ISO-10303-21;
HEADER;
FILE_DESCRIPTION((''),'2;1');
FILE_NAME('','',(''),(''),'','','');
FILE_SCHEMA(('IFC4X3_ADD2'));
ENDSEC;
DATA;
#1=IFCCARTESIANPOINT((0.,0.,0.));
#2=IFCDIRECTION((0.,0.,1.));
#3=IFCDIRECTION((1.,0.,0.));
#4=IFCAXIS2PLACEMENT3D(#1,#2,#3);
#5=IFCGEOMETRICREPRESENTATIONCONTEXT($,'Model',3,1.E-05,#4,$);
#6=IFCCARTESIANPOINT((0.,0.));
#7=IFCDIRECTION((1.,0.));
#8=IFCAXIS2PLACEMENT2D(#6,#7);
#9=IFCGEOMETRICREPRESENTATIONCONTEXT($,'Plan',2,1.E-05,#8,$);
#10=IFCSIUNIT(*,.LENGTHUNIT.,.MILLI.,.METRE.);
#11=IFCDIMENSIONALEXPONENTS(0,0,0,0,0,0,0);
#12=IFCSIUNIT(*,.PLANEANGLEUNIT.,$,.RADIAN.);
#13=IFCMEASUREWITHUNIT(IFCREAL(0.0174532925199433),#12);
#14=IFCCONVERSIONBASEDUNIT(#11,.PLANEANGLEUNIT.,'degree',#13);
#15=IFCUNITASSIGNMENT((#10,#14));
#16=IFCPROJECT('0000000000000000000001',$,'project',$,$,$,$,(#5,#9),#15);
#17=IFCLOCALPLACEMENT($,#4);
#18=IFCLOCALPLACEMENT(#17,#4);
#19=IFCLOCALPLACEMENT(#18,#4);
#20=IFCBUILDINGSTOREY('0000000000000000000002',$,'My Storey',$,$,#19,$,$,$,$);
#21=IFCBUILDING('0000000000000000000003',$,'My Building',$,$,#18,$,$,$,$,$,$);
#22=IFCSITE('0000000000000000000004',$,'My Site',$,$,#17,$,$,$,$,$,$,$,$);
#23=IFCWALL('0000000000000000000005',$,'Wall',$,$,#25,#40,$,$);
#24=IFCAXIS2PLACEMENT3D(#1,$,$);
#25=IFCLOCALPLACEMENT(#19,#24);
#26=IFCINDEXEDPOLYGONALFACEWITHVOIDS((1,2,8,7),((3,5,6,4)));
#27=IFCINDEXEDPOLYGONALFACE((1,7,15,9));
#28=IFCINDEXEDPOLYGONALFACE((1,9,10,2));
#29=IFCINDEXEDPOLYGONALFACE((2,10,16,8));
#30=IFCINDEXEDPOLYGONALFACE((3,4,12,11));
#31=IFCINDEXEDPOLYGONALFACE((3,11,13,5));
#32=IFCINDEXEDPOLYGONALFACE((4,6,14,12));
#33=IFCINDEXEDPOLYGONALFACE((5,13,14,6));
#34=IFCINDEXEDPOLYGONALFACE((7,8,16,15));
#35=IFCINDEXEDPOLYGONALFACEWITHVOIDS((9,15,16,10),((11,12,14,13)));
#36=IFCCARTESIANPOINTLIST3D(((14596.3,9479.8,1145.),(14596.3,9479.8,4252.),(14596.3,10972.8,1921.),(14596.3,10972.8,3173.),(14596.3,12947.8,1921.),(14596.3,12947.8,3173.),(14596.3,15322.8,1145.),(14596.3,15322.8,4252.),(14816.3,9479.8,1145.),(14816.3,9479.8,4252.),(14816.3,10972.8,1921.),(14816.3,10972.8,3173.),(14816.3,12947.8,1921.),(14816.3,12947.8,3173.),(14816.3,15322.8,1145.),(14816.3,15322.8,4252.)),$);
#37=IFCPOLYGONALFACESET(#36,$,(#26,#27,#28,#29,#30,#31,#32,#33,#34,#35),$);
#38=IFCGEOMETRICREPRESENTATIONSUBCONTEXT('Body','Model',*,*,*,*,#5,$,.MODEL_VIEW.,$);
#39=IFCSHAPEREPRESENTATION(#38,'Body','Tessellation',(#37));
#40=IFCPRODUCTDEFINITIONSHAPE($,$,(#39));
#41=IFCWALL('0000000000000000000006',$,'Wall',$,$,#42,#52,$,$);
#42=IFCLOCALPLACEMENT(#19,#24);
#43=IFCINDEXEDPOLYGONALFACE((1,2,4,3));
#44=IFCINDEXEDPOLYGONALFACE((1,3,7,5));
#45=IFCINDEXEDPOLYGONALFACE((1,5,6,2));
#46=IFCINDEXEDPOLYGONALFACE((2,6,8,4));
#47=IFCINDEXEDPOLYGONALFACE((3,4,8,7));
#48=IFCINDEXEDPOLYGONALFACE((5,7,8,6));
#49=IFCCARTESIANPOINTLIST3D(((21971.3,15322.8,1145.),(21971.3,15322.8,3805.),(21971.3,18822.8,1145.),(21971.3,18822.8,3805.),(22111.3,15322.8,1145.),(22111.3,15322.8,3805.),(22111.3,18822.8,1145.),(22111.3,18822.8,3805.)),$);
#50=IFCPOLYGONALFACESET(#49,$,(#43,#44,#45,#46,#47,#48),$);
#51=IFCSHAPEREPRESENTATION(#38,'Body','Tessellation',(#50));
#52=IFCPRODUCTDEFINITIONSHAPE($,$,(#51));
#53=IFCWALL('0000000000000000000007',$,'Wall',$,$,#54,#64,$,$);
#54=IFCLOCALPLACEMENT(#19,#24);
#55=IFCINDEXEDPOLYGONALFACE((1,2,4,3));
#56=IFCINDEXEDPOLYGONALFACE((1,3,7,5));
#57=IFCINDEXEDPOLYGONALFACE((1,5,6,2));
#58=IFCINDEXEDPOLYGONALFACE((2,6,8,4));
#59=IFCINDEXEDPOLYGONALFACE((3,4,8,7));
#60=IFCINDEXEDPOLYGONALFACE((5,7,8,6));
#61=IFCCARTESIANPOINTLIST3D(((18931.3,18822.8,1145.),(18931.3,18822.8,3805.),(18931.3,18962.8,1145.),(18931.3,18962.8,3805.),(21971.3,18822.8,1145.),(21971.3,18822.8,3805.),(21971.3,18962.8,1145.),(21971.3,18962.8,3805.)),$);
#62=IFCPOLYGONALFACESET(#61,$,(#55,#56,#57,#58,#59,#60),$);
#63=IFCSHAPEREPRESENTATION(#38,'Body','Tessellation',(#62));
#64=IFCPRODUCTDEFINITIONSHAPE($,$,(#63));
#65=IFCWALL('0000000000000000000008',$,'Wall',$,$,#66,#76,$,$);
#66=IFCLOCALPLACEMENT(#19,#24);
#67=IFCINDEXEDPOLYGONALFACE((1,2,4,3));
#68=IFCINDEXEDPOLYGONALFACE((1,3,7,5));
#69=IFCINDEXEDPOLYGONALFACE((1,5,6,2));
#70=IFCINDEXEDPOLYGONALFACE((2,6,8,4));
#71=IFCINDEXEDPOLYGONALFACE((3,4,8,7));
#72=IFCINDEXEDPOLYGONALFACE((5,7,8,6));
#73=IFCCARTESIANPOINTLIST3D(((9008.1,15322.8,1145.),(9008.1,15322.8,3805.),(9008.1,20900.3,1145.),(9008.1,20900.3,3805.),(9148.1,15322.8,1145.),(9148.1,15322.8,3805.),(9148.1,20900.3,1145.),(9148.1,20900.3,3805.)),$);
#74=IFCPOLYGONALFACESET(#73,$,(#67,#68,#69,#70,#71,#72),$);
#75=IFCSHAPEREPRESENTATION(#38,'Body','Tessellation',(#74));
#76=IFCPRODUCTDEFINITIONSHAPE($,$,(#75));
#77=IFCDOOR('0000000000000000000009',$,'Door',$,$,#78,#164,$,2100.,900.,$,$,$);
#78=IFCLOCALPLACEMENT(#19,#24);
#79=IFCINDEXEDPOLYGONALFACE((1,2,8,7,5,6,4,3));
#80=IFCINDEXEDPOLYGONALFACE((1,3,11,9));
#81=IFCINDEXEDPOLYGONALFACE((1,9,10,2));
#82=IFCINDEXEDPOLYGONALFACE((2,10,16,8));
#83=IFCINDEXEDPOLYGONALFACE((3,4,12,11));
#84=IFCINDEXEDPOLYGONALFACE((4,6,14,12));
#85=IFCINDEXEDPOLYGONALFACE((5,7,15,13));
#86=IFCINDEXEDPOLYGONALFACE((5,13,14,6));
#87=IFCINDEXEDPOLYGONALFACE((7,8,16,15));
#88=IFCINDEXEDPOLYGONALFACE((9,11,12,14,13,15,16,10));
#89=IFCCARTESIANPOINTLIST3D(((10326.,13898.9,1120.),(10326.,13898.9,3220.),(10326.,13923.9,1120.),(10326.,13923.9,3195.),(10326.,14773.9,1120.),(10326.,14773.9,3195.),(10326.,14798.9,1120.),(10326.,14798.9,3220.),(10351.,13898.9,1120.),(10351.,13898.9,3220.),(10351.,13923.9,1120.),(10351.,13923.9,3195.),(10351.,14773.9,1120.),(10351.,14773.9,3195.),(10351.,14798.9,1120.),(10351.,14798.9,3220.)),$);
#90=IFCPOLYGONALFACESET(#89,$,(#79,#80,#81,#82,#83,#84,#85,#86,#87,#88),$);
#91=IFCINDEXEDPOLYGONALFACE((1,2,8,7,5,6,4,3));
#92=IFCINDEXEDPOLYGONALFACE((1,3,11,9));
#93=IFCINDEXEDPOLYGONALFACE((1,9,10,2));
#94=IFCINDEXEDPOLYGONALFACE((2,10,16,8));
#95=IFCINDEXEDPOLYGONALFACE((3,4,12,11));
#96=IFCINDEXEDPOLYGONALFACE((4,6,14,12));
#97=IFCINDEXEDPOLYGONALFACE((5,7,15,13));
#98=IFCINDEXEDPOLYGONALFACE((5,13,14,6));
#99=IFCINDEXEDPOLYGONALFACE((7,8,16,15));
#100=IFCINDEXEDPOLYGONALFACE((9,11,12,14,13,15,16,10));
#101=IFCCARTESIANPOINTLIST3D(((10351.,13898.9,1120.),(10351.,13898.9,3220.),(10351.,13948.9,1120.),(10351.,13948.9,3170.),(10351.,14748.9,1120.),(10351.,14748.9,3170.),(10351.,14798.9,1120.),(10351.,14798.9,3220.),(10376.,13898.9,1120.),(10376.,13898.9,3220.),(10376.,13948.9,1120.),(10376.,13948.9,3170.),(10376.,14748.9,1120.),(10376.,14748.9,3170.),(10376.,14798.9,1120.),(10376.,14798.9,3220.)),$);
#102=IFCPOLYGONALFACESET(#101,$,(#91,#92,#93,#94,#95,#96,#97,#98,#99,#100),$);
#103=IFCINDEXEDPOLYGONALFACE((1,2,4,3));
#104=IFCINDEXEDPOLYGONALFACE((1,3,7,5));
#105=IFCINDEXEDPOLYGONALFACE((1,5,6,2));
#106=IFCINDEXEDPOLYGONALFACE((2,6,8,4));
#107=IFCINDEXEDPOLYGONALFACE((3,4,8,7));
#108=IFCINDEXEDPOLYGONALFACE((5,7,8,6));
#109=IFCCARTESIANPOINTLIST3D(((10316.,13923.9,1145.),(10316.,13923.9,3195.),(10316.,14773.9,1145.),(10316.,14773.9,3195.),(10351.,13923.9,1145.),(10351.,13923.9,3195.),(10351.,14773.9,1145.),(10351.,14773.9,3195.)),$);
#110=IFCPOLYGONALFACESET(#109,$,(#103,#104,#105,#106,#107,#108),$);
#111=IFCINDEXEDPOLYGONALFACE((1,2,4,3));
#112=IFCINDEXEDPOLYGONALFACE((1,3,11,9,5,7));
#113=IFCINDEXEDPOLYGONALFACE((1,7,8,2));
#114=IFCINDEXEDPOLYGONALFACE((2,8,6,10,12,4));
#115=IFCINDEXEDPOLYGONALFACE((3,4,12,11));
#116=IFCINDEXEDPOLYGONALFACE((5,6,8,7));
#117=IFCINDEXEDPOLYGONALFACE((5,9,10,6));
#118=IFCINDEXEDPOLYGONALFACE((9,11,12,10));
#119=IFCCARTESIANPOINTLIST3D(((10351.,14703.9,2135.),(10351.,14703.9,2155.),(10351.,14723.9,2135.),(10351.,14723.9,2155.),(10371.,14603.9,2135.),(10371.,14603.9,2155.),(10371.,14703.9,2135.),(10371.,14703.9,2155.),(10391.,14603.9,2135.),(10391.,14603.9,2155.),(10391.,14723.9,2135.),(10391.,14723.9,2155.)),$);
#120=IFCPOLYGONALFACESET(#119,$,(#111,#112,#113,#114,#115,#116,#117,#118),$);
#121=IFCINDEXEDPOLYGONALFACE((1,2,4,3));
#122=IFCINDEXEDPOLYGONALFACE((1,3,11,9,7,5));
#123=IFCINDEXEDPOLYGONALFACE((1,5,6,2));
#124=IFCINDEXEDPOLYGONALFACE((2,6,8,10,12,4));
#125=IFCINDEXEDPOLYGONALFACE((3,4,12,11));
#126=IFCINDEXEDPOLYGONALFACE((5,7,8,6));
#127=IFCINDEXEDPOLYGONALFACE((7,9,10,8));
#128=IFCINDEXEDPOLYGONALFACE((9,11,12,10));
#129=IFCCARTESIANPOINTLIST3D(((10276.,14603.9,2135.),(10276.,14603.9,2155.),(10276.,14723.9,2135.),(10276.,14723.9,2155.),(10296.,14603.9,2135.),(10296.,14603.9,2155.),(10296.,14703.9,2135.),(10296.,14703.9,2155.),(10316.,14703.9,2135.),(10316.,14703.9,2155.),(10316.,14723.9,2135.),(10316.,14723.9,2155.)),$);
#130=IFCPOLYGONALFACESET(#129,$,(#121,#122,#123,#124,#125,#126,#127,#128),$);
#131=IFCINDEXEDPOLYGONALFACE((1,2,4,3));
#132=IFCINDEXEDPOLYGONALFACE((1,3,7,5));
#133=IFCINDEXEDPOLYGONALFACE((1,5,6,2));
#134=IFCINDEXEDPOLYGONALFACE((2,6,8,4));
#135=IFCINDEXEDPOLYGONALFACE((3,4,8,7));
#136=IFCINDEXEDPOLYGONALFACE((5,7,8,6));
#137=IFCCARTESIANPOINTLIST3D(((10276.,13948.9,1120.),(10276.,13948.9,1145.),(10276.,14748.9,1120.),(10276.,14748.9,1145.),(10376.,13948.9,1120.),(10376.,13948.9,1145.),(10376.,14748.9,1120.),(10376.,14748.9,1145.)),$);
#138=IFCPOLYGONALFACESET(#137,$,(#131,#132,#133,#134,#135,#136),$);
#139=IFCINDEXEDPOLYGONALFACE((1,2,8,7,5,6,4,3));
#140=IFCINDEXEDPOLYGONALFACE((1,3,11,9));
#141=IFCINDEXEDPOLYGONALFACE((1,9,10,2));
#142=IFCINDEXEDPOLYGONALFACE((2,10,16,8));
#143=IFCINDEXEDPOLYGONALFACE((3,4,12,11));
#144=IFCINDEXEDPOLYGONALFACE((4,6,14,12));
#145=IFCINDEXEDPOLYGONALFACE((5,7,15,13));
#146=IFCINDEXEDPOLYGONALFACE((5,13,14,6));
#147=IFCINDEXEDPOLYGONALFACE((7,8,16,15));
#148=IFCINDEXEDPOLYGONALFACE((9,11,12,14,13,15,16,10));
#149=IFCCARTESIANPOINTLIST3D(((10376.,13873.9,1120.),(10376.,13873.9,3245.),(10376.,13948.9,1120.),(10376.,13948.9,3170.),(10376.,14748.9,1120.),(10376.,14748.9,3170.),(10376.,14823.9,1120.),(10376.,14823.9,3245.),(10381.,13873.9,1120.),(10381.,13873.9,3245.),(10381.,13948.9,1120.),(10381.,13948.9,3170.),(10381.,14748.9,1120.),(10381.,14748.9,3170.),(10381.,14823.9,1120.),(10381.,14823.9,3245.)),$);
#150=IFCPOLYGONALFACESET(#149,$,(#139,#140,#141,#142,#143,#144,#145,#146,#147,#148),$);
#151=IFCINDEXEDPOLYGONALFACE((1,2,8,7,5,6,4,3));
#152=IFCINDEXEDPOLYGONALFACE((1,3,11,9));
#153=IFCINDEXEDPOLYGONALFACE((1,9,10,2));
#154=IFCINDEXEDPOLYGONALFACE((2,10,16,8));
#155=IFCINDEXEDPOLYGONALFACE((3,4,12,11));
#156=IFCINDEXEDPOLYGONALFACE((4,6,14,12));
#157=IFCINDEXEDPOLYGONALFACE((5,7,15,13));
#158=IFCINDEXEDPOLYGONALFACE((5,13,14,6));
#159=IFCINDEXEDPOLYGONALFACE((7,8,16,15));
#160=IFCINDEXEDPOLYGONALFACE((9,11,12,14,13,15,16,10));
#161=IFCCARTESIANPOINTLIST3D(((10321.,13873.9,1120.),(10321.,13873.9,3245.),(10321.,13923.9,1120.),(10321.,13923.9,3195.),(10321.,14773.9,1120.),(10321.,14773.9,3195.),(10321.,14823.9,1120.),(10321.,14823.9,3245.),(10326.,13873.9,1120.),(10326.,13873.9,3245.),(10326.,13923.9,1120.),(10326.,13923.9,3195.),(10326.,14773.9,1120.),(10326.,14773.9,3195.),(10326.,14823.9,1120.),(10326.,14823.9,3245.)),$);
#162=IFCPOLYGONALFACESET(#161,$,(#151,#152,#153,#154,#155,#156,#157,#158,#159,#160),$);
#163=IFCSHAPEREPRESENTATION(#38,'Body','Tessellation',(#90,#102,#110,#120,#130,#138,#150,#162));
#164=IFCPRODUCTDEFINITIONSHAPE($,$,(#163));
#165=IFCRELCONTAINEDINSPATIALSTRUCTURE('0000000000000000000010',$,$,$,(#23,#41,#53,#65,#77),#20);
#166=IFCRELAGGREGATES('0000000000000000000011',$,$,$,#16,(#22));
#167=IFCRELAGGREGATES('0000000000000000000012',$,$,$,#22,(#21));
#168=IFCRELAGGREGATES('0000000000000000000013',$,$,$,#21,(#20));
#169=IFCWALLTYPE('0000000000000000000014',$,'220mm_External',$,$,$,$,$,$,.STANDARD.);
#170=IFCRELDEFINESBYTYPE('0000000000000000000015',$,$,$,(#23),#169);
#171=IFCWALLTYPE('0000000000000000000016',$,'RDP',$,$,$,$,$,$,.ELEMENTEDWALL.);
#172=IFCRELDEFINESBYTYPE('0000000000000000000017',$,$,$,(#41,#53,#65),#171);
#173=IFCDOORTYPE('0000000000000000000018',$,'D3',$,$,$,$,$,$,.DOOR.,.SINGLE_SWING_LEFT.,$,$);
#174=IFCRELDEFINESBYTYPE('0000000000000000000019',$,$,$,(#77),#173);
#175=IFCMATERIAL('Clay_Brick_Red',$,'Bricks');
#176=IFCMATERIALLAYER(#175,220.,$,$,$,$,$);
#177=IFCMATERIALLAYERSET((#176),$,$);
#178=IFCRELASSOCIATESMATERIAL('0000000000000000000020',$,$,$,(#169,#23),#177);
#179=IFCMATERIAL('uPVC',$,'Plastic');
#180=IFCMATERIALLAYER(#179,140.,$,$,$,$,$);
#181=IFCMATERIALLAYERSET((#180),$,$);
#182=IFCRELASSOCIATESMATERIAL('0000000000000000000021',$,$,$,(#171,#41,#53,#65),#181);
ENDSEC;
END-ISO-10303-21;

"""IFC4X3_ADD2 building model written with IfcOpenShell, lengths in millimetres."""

from ifc_helpers import new_model, entity, si_unit, converted_unit, frame, origin_with_axes, origin_2d_with_axis, place, context, subcontext, project, spatial, line, indexed_curve, outline, extrude, shape, source, transform, mapped, material, layer, layer_set, layer_usage, type_object, type_shapes, element, save


model = new_model("IFC4X3_ADD2")

# Units and contexts
model_context = context("Model", 3, precision=1e-05, world=origin_with_axes())
plan_context = context("Plan", 2, precision=1e-05, world=origin_2d_with_axis())
body_context_1 = subcontext(model_context, "Body", "Model", "MODEL_VIEW")
body_context_2 = subcontext(plan_context, "Body", "Plan", "PLAN_VIEW")
ifc_project = project(units=[si_unit("LENGTHUNIT", "METRE", prefix="MILLI"), converted_unit("PLANEANGLEUNIT", "degree", entity("IfcReal", 0.0174532925199433), si_unit("PLANEANGLEUNIT", "RADIAN"), dimensions=[0, 0, 0, 0, 0, 0, 0])], contexts=[model_context, plan_context])

# Site, building, storey
site_placement = place(None, origin_with_axes())
site = spatial("IfcSite", under=ifc_project, at=site_placement, Name="My Site")
building_placement = place(site_placement, origin_with_axes())
building = spatial("IfcBuilding", under=site, at=building_placement, Name="My Building")
storey_placement = place(building_placement, origin_with_axes())
storey = spatial("IfcBuildingStorey", under=building, at=storey_placement, Name="My Storey")

# Shared definitions
ifc_material_1 = material(Name="Clay_Brick_Red", Category="Bricks")
ifc_layer_1 = layer(ifc_material_1, 220.0)
ifc_layer_set_1 = layer_set([ifc_layer_1])
wall_type_1 = type_object("IfcWallType", Name="220mm_External", PredefinedType="STANDARD", material=ifc_layer_set_1)

# Wall, opening
ifc_layer_usage_1 = layer_usage(ifc_layer_set_1, "AXIS2", "POSITIVE", 0.0)
wall_1_placement = place(storey_placement, frame((14596.3, 15322.8, 1145.0), z_axis=(0.0, 0.0, 1.0), x_axis=(0.000001, -1.0, 0.0)))
wall_1 = element("IfcWall", 1, at=wall_1_placement, inside=storey, type_object=wall_type_1, material=ifc_layer_usage_1, Name="Wall", context=body_context_1, shape_type="SweptSolid", body=[
    extrude(outline(indexed_curve([(0.0, 0.0), (0.0, 220.0), (5843.0, 220.0), (5843.0, 0.0)], segments=[line(1, 2, 3, 4, 1)])), origin_with_axes(), (0.0, 0.0, 1.0), 3107.0),
])
opening_1_placement = place(wall_1_placement, frame((4350.0, -80.0, 776.0), z_axis=(0.0, 0.0, 1.0), x_axis=(0.000001, 1.0, 0.0)))
element("IfcOpeningElement", 2, at=opening_1_placement, cuts=wall_1, PredefinedType="OPENING", context=body_context_1, shape_type="SweptSolid", body=[
    extrude(outline(indexed_curve([(0.0, 1975.0), (500.0, 1975.0), (500.0, 0.0), (0.0, 0.0), (0.0, 1975.0)])), origin_with_axes(), (0.0, 0.0, 1.0), 1252.0),
])

# Shared definitions
ifc_material_2 = material(Name="uPVC", Category="Plastic")
ifc_layer_2 = layer(ifc_material_2, 140.0)
ifc_layer_set_2 = layer_set([ifc_layer_2])
wall_type_2 = type_object("IfcWallType", Name="RDP", PredefinedType="ELEMENTEDWALL", material=ifc_layer_set_2)

# Wall
ifc_layer_usage_2 = layer_usage(ifc_layer_set_2, "AXIS2", "POSITIVE", 0.0)
wall_2_placement = place(storey_placement, frame((22111.3, 15322.8, 1145.0), z_axis=(0.0, 0.0, 1.0), x_axis=(-0.000001, 1.0, 0.0)))
element("IfcWall", 3, at=wall_2_placement, inside=storey, type_object=wall_type_2, material=ifc_layer_usage_2, Name="Wall", context=body_context_1, shape_type="SweptSolid", body=[
    extrude(outline(indexed_curve([(0.0, 0.0), (0.0, 140.0), (3500.0, 140.0), (3500.0, 0.0)], segments=[line(1, 2, 3, 4, 1)])), origin_with_axes(), (0.0, 0.0, 1.0), 2660.0),
])

# Wall
ifc_layer_usage_3 = layer_usage(ifc_layer_set_2, "AXIS2", "POSITIVE", 0.0)
wall_3_placement = place(storey_placement, frame((18931.3, 18822.8, 1145.0), z_axis=(0.0, 0.0, 1.0), x_axis=(1.0, 0.000001, 0.0)))
element("IfcWall", 4, at=wall_3_placement, inside=storey, type_object=wall_type_2, material=ifc_layer_usage_3, Name="Wall", context=body_context_1, shape_type="SweptSolid", body=[
    extrude(outline(indexed_curve([(0.0, 0.0), (0.0, 140.0), (3040.0, 140.0), (3040.0, 0.0)], segments=[line(1, 2, 3, 4, 1)])), origin_with_axes(), (0.0, 0.0, 1.0), 2660.0),
])

# Wall
ifc_layer_usage_4 = layer_usage(ifc_layer_set_2, "AXIS2", "POSITIVE", 0.0)
wall_4_placement = place(storey_placement, frame((9148.1, 15322.8, 1145.0), z_axis=(0.0, 0.0, 1.0), x_axis=(-0.000004, 1.0, 0.0)))
element("IfcWall", 5, at=wall_4_placement, inside=storey, type_object=wall_type_2, material=ifc_layer_usage_4, Name="Wall", context=body_context_1, shape_type="SweptSolid", body=[
    extrude(outline(indexed_curve([(0.0, 0.0), (0.0, 140.0), (5577.6, 140.0), (5577.6, 0.0)], segments=[line(1, 2, 3, 4, 1)])), origin_with_axes(), (0.0, 0.0, 1.0), 2660.0),
])

# Door
door_type = type_object("IfcDoorType", Name="D3", OperationType="SINGLE_SWING_LEFT", PredefinedType="DOOR")
shared_shape_1 = source(origin_with_axes(), body_context_1, "Body", "SweptSolid", [
    extrude(outline(indexed_curve([(0.0, 0.0), (0.0, 2100.0), (900.0, 2100.0), (900.0, 0.0), (875.0, 0.0), (875.0, 2075.0), (25.0, 2075.0), (25.0, 0.0)], segments=[line(1, 2, 3, 4, 5, 6, 7, 8, 1)])), frame((0.0, 25.0, 0.0), z_axis=(0.0, -1.0, 0.0), x_axis=(1.0, 0.0, 0.0)), (0.0, 0.0, -1.0), 25.0),
    extrude(outline(indexed_curve([(0.0, 0.0), (0.0, 2100.0), (900.0, 2100.0), (900.0, 0.0), (850.0, 0.0), (850.0, 2050.0), (50.0, 2050.0), (50.0, 0.0)], segments=[line(1, 2, 3, 4, 5, 6, 7, 8, 1)])), frame((0.0, 0.0, 0.0), z_axis=(0.0, -1.0, 0.0), x_axis=(1.0, 0.0, 0.0)), (0.0, 0.0, -1.0), 25.0),
    extrude(outline(indexed_curve([(0.0, 0.0), (850.0, 0.0), (850.0, 35.0), (0.0, 35.0)], segments=[line(1, 2, 3, 4, 1)])), frame((25.0, 25.0, 25.0), z_axis=(0.0, 0.0, 1.0), x_axis=(1.0, 0.0, 0.0)), (0.0, 0.0, 1.0), 2050.0),
    extrude(outline(indexed_curve([(0.0, 0.0), (0.0, -40.0), (-120.0, -40.0), (-120.0, -20.0), (-20.0, -20.0), (-20.0, 0.0)], segments=[line(1, 2, 3, 4, 5, 6, 1)])), frame((825.0, 25.0, 1015.0), z_axis=(0.0, 0.0, 1.0), x_axis=(1.0, 0.0, 0.0)), (0.0, 0.0, 1.0), 20.0),
    extrude(outline(indexed_curve([(0.0, 0.0), (0.0, 40.0), (-120.0, 40.0), (-120.0, 20.0), (-20.0, 20.0), (-20.0, 0.0)], segments=[line(1, 2, 3, 4, 5, 6, 1)])), frame((825.0, 60.0, 1015.0), z_axis=(0.0, 0.0, 1.0), x_axis=(1.0, 0.0, 0.0)), (0.0, 0.0, 1.0), 20.0),
    extrude(outline(indexed_curve([(0.0, 0.0), (800.0, 0.0), (800.0, 100.0), (0.0, 100.0)], segments=[line(1, 2, 3, 4, 1)])), frame((50.0, 0.0, 0.0), z_axis=(0.0, 0.0, 1.0), x_axis=(1.0, 0.0, 0.0)), (0.0, 0.0, 1.0), 25.0),
    extrude(outline(indexed_curve([(0.0, 0.0), (0.0, 2125.0), (950.0, 2125.0), (950.0, 0.0), (875.0, 0.0), (875.0, 2050.0), (75.0, 2050.0), (75.0, 0.0)], segments=[line(1, 2, 3, 4, 5, 6, 7, 8, 1)])), frame((-25.0, -5.0, 0.0), z_axis=(0.0, -1.0, 0.0), x_axis=(1.0, 0.0, 0.0)), (0.0, 0.0, -1.0), 5.0),
    extrude(outline(indexed_curve([(0.0, 0.0), (0.0, 2125.0), (950.0, 2125.0), (950.0, 0.0), (900.0, 0.0), (900.0, 2075.0), (50.0, 2075.0), (50.0, 0.0)], segments=[line(1, 2, 3, 4, 5, 6, 7, 8, 1)])), frame((-25.0, 50.0, 0.0), z_axis=(0.0, -1.0, 0.0), x_axis=(1.0, 0.0, 0.0)), (0.0, 0.0, -1.0), 5.0),
])
shared_shape_2 = source(origin_with_axes(), body_context_2, "Body", "Curve2D", [
    entity("IfcIndexedPolyCurve", entity("IfcCartesianPointList2D", [[0.0, 0.0], [0.0, 50.0], [25.0, 50.0], [25.0, 25.0], [50.0, 25.0], [50.0, 0.0]]), [entity("IfcLineIndex", [1, 2, 3, 4, 5, 6, 1])]),
    entity("IfcIndexedPolyCurve", entity("IfcCartesianPointList2D", [[900.0, 0.0], [900.0, 50.0], [875.0, 50.0], [875.0, 25.0], [850.0, 25.0], [850.0, 0.0]]), [entity("IfcLineIndex", [1, 2, 3, 4, 5, 6, 1])]),
    entity("IfcTrimmedCurve", entity("IfcEllipse", entity("IfcAxis2Placement2D", entity("IfcCartesianPoint", [60.0, 50.0]), entity("IfcDirection", [1.0, 0.0])), 815.0, 850.0), [entity("IfcCartesianPoint", [875.0, 50.0])], [entity("IfcCartesianPoint", [60.0, 900.0])], True, "CARTESIAN"),
    entity("IfcIndexedPolyCurve", entity("IfcCartesianPointList2D", [[25.0, 50.0], [60.0, 50.0], [60.0, 900.0], [25.0, 900.0]]), [entity("IfcLineIndex", [1, 2, 3, 4, 1])]),
])
type_shapes(door_type, [shared_shape_1, shared_shape_2])
door_placement = place(storey_placement, frame((10376.0, 13898.9, 1120.0), z_axis=(0.0, 0.0, 1.0), x_axis=(0.0, 1.0, 0.0)))
element("IfcDoor", 6, at=door_placement, inside=storey, type_object=door_type, Name="Door", OverallHeight=2100.0, OverallWidth=900.0, shapes=[
    shape(body_context_1, "Body", "MappedRepresentation", [mapped(shared_shape_1, transform((0.0, 0.0, 0.0), x_axis=(1.0, 0.0, 0.0), y_axis=(0.0, 1.0, 0.0), z_axis=(0.0, 0.0, 1.0), scale=1.0))]),
    shape(body_context_2, "Body", "MappedRepresentation", [mapped(shared_shape_2, transform((0.0, 0.0, 0.0), x_axis=(1.0, 0.0, 0.0), y_axis=(0.0, 1.0, 0.0), z_axis=(0.0, 0.0, 1.0), scale=1.0))]),
])

save(model, "model.ifc")
